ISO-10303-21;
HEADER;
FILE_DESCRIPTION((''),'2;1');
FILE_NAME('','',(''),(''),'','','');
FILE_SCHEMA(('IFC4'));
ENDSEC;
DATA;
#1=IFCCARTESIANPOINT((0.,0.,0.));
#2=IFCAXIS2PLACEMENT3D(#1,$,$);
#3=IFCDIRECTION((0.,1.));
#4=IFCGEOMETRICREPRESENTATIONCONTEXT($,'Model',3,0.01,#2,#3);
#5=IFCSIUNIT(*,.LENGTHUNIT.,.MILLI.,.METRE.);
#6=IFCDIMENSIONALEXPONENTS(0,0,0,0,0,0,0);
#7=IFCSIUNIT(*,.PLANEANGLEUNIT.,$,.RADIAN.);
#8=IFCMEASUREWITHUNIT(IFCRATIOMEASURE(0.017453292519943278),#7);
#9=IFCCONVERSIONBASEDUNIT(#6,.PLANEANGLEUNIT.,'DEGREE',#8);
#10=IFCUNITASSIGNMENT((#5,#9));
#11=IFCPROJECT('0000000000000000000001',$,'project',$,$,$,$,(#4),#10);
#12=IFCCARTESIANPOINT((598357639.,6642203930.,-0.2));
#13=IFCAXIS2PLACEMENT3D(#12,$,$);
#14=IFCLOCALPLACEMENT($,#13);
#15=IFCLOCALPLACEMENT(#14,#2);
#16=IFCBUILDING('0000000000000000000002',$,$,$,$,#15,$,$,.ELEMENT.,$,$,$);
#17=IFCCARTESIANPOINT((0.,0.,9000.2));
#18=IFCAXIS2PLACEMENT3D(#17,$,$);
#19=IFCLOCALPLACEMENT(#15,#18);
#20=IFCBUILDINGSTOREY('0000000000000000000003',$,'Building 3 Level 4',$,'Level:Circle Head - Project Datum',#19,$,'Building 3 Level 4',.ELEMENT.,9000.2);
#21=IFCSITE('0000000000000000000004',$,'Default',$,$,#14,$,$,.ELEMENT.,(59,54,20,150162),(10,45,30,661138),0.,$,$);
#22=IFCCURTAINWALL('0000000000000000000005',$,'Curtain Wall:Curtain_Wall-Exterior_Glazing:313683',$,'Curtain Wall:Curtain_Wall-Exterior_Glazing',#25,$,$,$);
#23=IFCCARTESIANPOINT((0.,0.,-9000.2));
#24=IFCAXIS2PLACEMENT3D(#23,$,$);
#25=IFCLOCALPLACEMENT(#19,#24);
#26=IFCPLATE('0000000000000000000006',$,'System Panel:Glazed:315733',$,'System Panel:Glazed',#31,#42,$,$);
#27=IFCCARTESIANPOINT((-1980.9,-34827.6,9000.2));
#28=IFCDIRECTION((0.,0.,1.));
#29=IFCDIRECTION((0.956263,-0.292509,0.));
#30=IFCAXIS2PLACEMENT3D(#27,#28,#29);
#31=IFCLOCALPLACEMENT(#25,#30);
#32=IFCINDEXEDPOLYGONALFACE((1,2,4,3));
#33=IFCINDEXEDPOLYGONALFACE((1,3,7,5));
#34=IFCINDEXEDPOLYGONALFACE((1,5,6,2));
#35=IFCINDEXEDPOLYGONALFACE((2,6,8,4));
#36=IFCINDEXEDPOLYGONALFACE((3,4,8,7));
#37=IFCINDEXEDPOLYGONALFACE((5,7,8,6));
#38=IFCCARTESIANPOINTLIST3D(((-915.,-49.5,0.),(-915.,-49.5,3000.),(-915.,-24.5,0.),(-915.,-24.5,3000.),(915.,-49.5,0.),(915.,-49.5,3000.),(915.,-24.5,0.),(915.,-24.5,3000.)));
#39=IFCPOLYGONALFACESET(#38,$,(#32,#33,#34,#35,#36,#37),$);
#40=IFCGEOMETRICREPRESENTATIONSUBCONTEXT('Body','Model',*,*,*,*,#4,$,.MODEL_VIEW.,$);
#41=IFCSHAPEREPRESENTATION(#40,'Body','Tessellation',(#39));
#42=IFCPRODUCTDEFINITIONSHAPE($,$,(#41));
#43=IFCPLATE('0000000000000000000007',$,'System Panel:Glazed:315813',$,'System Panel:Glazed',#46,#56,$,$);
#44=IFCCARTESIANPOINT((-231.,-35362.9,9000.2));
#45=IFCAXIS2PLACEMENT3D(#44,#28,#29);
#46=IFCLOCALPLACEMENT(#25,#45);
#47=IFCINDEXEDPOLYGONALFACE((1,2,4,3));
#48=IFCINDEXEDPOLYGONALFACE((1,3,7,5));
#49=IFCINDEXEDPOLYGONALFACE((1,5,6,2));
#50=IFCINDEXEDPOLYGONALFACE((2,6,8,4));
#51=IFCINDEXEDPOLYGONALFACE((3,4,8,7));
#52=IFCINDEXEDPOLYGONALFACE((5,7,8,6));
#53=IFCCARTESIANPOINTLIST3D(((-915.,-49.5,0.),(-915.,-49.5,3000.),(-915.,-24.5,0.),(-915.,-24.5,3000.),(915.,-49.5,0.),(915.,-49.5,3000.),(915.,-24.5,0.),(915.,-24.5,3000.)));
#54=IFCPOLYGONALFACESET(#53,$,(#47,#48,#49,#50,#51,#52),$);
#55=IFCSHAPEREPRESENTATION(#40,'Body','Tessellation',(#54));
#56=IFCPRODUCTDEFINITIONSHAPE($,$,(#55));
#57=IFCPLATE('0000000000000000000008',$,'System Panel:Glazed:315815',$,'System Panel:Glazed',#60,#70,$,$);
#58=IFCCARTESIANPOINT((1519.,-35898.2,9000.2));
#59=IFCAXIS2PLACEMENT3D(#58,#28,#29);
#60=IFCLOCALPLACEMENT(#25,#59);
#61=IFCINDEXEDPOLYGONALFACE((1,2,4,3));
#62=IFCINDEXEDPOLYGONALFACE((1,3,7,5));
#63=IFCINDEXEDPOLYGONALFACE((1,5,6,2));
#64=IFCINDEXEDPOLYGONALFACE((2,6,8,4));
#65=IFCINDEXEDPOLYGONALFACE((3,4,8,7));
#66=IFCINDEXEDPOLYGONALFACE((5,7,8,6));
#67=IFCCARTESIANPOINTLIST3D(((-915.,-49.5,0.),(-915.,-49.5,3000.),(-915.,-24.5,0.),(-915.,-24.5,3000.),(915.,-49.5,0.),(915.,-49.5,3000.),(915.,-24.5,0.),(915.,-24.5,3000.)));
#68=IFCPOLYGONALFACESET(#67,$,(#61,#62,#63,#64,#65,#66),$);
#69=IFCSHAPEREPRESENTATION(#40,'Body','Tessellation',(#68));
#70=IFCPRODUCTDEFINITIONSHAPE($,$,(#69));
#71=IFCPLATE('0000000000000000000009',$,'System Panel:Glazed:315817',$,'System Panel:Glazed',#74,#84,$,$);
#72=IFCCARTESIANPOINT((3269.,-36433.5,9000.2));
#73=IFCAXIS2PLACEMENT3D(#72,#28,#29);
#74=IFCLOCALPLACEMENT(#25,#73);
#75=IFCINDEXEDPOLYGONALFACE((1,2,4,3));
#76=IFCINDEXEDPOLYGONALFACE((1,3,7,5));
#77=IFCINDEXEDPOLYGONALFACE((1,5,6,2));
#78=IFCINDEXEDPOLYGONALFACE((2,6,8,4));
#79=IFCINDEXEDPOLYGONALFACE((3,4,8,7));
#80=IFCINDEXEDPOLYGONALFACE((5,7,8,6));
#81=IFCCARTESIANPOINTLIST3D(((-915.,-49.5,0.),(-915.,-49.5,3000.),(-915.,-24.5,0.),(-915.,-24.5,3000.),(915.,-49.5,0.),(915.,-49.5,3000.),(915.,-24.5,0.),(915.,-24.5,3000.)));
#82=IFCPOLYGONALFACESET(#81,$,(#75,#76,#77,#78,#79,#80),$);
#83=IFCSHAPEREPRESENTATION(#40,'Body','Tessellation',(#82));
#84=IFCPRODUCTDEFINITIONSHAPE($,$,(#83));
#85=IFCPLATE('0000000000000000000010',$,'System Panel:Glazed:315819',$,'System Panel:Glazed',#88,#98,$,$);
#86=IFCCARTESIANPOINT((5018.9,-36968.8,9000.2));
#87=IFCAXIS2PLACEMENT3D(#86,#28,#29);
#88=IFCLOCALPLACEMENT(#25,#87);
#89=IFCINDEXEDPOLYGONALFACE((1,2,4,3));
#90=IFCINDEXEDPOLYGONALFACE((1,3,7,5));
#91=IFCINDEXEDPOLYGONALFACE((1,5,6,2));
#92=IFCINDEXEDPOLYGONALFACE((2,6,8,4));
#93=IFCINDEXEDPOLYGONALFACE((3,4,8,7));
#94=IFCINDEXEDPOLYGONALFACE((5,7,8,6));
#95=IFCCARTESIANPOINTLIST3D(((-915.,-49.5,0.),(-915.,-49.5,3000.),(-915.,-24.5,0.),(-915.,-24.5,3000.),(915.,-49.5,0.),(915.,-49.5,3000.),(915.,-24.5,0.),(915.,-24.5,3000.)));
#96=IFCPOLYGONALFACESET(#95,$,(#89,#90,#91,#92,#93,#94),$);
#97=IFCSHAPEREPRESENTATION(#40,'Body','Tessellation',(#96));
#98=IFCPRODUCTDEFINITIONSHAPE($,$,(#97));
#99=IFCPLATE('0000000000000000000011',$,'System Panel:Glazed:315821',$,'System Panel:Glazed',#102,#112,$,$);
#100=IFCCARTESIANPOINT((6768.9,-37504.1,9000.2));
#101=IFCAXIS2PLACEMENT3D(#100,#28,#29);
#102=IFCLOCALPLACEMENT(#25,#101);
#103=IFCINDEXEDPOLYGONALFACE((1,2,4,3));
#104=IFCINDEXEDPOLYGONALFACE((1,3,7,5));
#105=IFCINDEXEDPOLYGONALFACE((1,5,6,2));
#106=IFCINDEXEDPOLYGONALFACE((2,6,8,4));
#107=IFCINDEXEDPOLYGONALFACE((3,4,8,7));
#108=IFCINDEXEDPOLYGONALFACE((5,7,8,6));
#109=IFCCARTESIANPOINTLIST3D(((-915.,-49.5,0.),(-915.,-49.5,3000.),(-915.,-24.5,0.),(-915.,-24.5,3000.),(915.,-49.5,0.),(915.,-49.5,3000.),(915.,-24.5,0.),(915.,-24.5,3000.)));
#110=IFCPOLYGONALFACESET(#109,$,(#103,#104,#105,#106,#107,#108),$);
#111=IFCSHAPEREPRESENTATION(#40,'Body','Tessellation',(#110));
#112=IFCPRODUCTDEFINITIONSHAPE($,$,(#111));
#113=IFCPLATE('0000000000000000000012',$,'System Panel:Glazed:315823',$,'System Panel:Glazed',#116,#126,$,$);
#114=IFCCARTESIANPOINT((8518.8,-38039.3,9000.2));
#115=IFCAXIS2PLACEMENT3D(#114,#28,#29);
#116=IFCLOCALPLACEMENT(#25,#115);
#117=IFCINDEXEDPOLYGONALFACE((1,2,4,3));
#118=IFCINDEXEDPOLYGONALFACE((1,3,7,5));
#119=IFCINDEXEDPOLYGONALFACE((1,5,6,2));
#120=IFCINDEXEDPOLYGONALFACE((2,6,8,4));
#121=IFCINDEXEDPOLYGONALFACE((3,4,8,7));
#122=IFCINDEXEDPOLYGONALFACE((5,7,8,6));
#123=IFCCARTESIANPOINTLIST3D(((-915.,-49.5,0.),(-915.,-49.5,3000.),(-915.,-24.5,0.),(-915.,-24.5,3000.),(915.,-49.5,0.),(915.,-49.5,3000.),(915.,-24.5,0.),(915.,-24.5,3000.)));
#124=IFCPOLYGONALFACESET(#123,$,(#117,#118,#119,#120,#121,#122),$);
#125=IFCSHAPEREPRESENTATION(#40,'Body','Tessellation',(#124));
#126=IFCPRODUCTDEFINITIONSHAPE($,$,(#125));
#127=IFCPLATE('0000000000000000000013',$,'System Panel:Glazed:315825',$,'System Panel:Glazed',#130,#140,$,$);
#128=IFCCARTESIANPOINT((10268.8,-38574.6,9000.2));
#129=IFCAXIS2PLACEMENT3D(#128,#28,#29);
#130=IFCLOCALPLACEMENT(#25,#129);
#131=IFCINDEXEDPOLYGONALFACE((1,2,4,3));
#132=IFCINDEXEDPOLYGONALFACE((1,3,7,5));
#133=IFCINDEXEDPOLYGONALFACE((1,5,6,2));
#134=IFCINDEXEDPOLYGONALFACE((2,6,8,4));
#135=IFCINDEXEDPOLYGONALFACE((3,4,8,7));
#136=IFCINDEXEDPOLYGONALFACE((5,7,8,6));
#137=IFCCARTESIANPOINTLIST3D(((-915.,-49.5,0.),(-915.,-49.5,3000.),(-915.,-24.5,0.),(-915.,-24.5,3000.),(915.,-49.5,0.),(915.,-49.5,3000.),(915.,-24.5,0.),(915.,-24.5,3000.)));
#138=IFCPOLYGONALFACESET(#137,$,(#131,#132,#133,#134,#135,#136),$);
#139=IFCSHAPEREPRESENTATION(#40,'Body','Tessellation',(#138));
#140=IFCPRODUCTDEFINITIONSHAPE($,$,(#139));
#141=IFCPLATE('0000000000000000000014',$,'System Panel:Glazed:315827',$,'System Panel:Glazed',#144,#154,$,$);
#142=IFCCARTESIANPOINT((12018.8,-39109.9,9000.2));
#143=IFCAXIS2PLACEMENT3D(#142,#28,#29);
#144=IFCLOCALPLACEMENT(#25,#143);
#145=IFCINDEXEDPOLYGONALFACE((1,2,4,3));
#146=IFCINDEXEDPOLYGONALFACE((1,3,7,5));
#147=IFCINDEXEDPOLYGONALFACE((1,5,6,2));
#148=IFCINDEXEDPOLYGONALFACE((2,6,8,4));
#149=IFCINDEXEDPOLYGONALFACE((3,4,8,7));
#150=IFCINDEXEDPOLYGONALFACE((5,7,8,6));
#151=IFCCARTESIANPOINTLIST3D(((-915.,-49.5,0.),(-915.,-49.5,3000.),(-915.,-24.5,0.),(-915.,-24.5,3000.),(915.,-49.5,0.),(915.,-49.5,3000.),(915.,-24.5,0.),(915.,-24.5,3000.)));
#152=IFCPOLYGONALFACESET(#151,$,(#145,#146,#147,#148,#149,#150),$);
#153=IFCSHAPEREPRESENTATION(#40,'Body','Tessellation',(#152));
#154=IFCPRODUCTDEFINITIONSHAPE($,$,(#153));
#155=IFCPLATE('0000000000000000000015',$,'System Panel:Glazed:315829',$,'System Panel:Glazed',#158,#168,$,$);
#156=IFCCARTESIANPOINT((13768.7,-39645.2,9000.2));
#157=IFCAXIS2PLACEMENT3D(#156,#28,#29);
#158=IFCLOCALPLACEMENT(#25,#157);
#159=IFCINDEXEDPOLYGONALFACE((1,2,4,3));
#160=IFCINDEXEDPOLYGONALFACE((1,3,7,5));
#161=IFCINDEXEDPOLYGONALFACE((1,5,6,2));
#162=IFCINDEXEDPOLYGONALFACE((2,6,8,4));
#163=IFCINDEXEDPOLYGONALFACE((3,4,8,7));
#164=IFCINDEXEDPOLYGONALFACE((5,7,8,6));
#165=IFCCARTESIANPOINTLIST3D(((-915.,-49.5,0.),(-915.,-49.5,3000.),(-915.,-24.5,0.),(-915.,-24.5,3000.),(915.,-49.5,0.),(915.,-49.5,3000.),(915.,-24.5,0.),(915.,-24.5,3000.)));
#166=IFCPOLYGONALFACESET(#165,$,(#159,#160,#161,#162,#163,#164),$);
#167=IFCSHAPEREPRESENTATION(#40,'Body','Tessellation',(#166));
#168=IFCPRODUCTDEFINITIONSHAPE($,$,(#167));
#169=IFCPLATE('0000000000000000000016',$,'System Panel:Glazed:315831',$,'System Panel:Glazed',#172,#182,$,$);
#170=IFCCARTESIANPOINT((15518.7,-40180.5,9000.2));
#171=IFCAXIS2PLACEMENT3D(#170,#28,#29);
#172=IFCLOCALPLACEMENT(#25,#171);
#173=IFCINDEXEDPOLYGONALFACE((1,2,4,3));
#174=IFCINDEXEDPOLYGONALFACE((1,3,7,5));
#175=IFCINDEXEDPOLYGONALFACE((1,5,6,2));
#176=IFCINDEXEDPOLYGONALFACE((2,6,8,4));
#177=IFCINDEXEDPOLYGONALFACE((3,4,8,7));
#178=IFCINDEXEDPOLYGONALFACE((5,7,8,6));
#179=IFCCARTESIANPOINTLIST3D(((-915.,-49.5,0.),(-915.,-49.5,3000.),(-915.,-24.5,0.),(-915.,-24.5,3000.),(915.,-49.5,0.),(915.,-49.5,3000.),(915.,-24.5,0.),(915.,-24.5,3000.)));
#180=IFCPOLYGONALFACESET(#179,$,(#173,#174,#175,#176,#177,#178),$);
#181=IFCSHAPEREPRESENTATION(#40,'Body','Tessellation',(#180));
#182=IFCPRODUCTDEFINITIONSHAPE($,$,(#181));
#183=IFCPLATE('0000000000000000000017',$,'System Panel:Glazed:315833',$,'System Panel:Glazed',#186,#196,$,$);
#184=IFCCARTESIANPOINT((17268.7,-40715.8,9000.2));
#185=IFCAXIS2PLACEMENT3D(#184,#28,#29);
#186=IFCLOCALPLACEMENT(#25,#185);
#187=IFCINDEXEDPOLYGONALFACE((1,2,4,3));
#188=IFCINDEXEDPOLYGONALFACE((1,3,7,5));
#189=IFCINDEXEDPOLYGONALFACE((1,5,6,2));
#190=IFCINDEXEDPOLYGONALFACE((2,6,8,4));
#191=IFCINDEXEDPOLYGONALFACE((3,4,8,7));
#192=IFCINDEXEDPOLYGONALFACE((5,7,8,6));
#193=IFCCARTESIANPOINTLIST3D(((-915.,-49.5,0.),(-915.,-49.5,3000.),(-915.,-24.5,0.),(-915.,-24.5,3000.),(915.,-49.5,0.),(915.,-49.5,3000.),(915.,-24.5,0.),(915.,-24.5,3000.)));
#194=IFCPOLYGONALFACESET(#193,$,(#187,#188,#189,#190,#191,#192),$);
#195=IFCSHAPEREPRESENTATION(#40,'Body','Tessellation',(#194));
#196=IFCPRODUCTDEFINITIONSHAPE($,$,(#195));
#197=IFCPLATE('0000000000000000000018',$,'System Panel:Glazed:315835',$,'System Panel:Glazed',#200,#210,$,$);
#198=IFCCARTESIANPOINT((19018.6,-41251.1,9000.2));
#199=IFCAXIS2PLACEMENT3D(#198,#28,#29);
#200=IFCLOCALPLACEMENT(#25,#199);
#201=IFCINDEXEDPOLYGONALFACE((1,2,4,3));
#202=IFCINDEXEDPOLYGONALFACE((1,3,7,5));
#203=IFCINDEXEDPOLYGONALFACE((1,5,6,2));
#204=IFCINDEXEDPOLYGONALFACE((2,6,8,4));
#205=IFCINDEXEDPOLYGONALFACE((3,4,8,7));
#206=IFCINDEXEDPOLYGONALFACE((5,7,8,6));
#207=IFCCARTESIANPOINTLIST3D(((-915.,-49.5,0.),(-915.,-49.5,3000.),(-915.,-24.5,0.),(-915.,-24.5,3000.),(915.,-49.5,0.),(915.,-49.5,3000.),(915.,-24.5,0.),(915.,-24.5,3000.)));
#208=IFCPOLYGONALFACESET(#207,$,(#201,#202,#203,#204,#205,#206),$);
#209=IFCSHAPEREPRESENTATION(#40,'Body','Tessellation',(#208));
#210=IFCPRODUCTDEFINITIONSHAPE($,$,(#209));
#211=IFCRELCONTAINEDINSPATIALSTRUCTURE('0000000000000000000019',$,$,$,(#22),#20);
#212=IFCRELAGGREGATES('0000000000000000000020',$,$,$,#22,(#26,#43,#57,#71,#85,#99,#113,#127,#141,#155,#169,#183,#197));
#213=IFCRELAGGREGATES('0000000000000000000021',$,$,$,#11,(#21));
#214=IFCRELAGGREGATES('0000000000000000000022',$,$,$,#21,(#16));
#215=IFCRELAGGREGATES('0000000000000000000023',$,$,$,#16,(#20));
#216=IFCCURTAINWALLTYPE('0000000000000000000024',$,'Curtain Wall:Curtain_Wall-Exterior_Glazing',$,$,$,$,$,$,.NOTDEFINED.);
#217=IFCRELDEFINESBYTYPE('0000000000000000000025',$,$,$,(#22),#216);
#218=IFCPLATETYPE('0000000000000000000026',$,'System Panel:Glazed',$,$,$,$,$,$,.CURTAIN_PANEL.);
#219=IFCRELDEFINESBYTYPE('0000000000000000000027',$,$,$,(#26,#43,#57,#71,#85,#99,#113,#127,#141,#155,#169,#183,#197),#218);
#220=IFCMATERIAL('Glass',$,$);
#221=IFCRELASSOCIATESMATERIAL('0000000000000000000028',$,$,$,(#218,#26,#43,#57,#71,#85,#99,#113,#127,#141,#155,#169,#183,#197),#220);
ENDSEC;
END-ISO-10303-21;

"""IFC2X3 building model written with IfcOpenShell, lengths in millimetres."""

from ifc_helpers import new_model, entity, si_unit, converted_unit, direction, frame, frame_2d, origin, place, context, subcontext, project, spatial, rectangle, extrude, source, transform, mapped, material, type_object, type_shapes, element, aggregate, save


model = new_model("IFC2X3")

# Units and contexts
model_context = context("Model", 3, precision=0.01, world=origin(), true_north=direction((0.0, 1.0)))
body_context = subcontext(model_context, "Body", "Model", "MODEL_VIEW")
ifc_project = project(units=[si_unit("LENGTHUNIT", "METRE", prefix="MILLI"), converted_unit("PLANEANGLEUNIT", "DEGREE", entity("IfcRatioMeasure", 0.017453292519943278), si_unit("PLANEANGLEUNIT", "RADIAN"), dimensions=[0, 0, 0, 0, 0, 0, 0])], contexts=[model_context])

# Site, building, storey
site_placement = place(None, frame((598357639.0, 6642203930.0, -0.2)))
site = spatial("IfcSite", under=ifc_project, at=site_placement, Name="Default", CompositionType="ELEMENT", RefLatitude=(59, 54, 20, 150162), RefLongitude=(10, 45, 30, 661138), RefElevation=0.0)
building_placement = place(site_placement, origin())
building = spatial("IfcBuilding", under=site, at=building_placement, CompositionType="ELEMENT")
storey_placement = place(building_placement, frame((0.0, 0.0, 9000.2)))
storey = spatial("IfcBuildingStorey", under=building, at=storey_placement, Name="Building 3 Level 4", ObjectType="Level:Circle Head - Project Datum", LongName="Building 3 Level 4", CompositionType="ELEMENT", Elevation=9000.2)

# Curtain wall, plates
curtain_wall_type = type_object("IfcCurtainWallType", Name="Curtain Wall:Curtain_Wall-Exterior_Glazing", PredefinedType="NOTDEFINED")
ifc_material_1 = material(Name="Glass")
plate_type_1 = type_object("IfcPlateType", Name="System Panel:Glazed", PredefinedType="CURTAIN_PANEL", material=ifc_material_1)
shared_shape_1 = source(origin(), body_context, "Body", "SweptSolid", [
    extrude(rectangle(XDim=25.0, YDim=1830.0, at=frame_2d((0.0, 0.0), x_axis=(1.0, 0.0))), frame((0.0, -37.0, 0.0), z_axis=(0.0, 0.0, 1.0), x_axis=(0.0, 1.0, 0.0)), (0.0, 0.0, 1.0), 3000.0),
])
type_shapes(plate_type_1, [shared_shape_1])
curtain_wall_1_placement = place(storey_placement, frame((0.0, 0.0, -9000.2)))
curtain_wall_1 = element("IfcCurtainWall", 1, at=curtain_wall_1_placement, inside=storey, type_object=curtain_wall_type, Name="Curtain Wall:Curtain_Wall-Exterior_Glazing:313683", ObjectType="Curtain Wall:Curtain_Wall-Exterior_Glazing")
plate_1_placement = place(curtain_wall_1_placement, frame((-1980.9, -34827.6, 9000.2), z_axis=(0.0, 0.0, 1.0), x_axis=(0.956263, -0.292509, 0.0)))
plate_1 = element("IfcPlate", 2, at=plate_1_placement, type_object=plate_type_1, material=ifc_material_1, Name="System Panel:Glazed:315733", ObjectType="System Panel:Glazed", context=body_context, shape_type="MappedRepresentation", body=[
    mapped(shared_shape_1, transform((0.0, 0.0, 0.0), scale=1.0)),
])
plate_2_placement = place(curtain_wall_1_placement, frame((-231.0, -35362.9, 9000.2), z_axis=(0.0, 0.0, 1.0), x_axis=(0.956263, -0.292509, 0.0)))
plate_2 = element("IfcPlate", 3, at=plate_2_placement, type_object=plate_type_1, material=ifc_material_1, Name="System Panel:Glazed:315813", ObjectType="System Panel:Glazed", context=body_context, shape_type="MappedRepresentation", body=[
    mapped(shared_shape_1, transform((0.0, 0.0, 0.0), scale=1.0)),
])
plate_3_placement = place(curtain_wall_1_placement, frame((1519.0, -35898.2, 9000.2), z_axis=(0.0, 0.0, 1.0), x_axis=(0.956263, -0.292509, 0.0)))
plate_3 = element("IfcPlate", 4, at=plate_3_placement, type_object=plate_type_1, material=ifc_material_1, Name="System Panel:Glazed:315815", ObjectType="System Panel:Glazed", context=body_context, shape_type="MappedRepresentation", body=[
    mapped(shared_shape_1, transform((0.0, 0.0, 0.0), scale=1.0)),
])
plate_4_placement = place(curtain_wall_1_placement, frame((3269.0, -36433.5, 9000.2), z_axis=(0.0, 0.0, 1.0), x_axis=(0.956263, -0.292509, 0.0)))
plate_4 = element("IfcPlate", 5, at=plate_4_placement, type_object=plate_type_1, material=ifc_material_1, Name="System Panel:Glazed:315817", ObjectType="System Panel:Glazed", context=body_context, shape_type="MappedRepresentation", body=[
    mapped(shared_shape_1, transform((0.0, 0.0, 0.0), scale=1.0)),
])
plate_5_placement = place(curtain_wall_1_placement, frame((5018.9, -36968.8, 9000.2), z_axis=(0.0, 0.0, 1.0), x_axis=(0.956263, -0.292509, 0.0)))
plate_5 = element("IfcPlate", 6, at=plate_5_placement, type_object=plate_type_1, material=ifc_material_1, Name="System Panel:Glazed:315819", ObjectType="System Panel:Glazed", context=body_context, shape_type="MappedRepresentation", body=[
    mapped(shared_shape_1, transform((0.0, 0.0, 0.0), scale=1.0)),
])
plate_6_placement = place(curtain_wall_1_placement, frame((6768.9, -37504.1, 9000.2), z_axis=(0.0, 0.0, 1.0), x_axis=(0.956263, -0.292509, 0.0)))
plate_6 = element("IfcPlate", 7, at=plate_6_placement, type_object=plate_type_1, material=ifc_material_1, Name="System Panel:Glazed:315821", ObjectType="System Panel:Glazed", context=body_context, shape_type="MappedRepresentation", body=[
    mapped(shared_shape_1, transform((0.0, 0.0, 0.0), scale=1.0)),
])
plate_7_placement = place(curtain_wall_1_placement, frame((8518.8, -38039.3, 9000.2), z_axis=(0.0, 0.0, 1.0), x_axis=(0.956263, -0.292509, 0.0)))
plate_7 = element("IfcPlate", 8, at=plate_7_placement, type_object=plate_type_1, material=ifc_material_1, Name="System Panel:Glazed:315823", ObjectType="System Panel:Glazed", context=body_context, shape_type="MappedRepresentation", body=[
    mapped(shared_shape_1, transform((0.0, 0.0, 0.0), scale=1.0)),
])
plate_8_placement = place(curtain_wall_1_placement, frame((10268.8, -38574.6, 9000.2), z_axis=(0.0, 0.0, 1.0), x_axis=(0.956263, -0.292509, 0.0)))
plate_8 = element("IfcPlate", 9, at=plate_8_placement, type_object=plate_type_1, material=ifc_material_1, Name="System Panel:Glazed:315825", ObjectType="System Panel:Glazed", context=body_context, shape_type="MappedRepresentation", body=[
    mapped(shared_shape_1, transform((0.0, 0.0, 0.0), scale=1.0)),
])
plate_9_placement = place(curtain_wall_1_placement, frame((12018.8, -39109.9, 9000.2), z_axis=(0.0, 0.0, 1.0), x_axis=(0.956263, -0.292509, 0.0)))
plate_9 = element("IfcPlate", 10, at=plate_9_placement, type_object=plate_type_1, material=ifc_material_1, Name="System Panel:Glazed:315827", ObjectType="System Panel:Glazed", context=body_context, shape_type="MappedRepresentation", body=[
    mapped(shared_shape_1, transform((0.0, 0.0, 0.0), scale=1.0)),
])
plate_10_placement = place(curtain_wall_1_placement, frame((13768.7, -39645.2, 9000.2), z_axis=(0.0, 0.0, 1.0), x_axis=(0.956263, -0.292509, 0.0)))
plate_10 = element("IfcPlate", 11, at=plate_10_placement, type_object=plate_type_1, material=ifc_material_1, Name="System Panel:Glazed:315829", ObjectType="System Panel:Glazed", context=body_context, shape_type="MappedRepresentation", body=[
    mapped(shared_shape_1, transform((0.0, 0.0, 0.0), scale=1.0)),
])
plate_11_placement = place(curtain_wall_1_placement, frame((15518.7, -40180.5, 9000.2), z_axis=(0.0, 0.0, 1.0), x_axis=(0.956263, -0.292509, 0.0)))
plate_11 = element("IfcPlate", 12, at=plate_11_placement, type_object=plate_type_1, material=ifc_material_1, Name="System Panel:Glazed:315831", ObjectType="System Panel:Glazed", context=body_context, shape_type="MappedRepresentation", body=[
    mapped(shared_shape_1, transform((0.0, 0.0, 0.0), scale=1.0)),
])
plate_12_placement = place(curtain_wall_1_placement, frame((17268.7, -40715.8, 9000.2), z_axis=(0.0, 0.0, 1.0), x_axis=(0.956263, -0.292509, 0.0)))
plate_12 = element("IfcPlate", 13, at=plate_12_placement, type_object=plate_type_1, material=ifc_material_1, Name="System Panel:Glazed:315833", ObjectType="System Panel:Glazed", context=body_context, shape_type="MappedRepresentation", body=[
    mapped(shared_shape_1, transform((0.0, 0.0, 0.0), scale=1.0)),
])
plate_13_placement = place(curtain_wall_1_placement, frame((19018.6, -41251.1, 9000.2), z_axis=(0.0, 0.0, 1.0), x_axis=(0.956263, -0.292509, 0.0)))
plate_13 = element("IfcPlate", 14, at=plate_13_placement, type_object=plate_type_1, material=ifc_material_1, Name="System Panel:Glazed:315835", ObjectType="System Panel:Glazed", context=body_context, shape_type="MappedRepresentation", body=[
    mapped(shared_shape_1, transform((0.0, 0.0, 0.0), scale=1.0)),
])

aggregate(curtain_wall_1, [plate_1, plate_2, plate_3, plate_4, plate_5, plate_6, plate_7, plate_8, plate_9, plate_10, plate_11, plate_12, plate_13])

save(model, "model.ifc")
